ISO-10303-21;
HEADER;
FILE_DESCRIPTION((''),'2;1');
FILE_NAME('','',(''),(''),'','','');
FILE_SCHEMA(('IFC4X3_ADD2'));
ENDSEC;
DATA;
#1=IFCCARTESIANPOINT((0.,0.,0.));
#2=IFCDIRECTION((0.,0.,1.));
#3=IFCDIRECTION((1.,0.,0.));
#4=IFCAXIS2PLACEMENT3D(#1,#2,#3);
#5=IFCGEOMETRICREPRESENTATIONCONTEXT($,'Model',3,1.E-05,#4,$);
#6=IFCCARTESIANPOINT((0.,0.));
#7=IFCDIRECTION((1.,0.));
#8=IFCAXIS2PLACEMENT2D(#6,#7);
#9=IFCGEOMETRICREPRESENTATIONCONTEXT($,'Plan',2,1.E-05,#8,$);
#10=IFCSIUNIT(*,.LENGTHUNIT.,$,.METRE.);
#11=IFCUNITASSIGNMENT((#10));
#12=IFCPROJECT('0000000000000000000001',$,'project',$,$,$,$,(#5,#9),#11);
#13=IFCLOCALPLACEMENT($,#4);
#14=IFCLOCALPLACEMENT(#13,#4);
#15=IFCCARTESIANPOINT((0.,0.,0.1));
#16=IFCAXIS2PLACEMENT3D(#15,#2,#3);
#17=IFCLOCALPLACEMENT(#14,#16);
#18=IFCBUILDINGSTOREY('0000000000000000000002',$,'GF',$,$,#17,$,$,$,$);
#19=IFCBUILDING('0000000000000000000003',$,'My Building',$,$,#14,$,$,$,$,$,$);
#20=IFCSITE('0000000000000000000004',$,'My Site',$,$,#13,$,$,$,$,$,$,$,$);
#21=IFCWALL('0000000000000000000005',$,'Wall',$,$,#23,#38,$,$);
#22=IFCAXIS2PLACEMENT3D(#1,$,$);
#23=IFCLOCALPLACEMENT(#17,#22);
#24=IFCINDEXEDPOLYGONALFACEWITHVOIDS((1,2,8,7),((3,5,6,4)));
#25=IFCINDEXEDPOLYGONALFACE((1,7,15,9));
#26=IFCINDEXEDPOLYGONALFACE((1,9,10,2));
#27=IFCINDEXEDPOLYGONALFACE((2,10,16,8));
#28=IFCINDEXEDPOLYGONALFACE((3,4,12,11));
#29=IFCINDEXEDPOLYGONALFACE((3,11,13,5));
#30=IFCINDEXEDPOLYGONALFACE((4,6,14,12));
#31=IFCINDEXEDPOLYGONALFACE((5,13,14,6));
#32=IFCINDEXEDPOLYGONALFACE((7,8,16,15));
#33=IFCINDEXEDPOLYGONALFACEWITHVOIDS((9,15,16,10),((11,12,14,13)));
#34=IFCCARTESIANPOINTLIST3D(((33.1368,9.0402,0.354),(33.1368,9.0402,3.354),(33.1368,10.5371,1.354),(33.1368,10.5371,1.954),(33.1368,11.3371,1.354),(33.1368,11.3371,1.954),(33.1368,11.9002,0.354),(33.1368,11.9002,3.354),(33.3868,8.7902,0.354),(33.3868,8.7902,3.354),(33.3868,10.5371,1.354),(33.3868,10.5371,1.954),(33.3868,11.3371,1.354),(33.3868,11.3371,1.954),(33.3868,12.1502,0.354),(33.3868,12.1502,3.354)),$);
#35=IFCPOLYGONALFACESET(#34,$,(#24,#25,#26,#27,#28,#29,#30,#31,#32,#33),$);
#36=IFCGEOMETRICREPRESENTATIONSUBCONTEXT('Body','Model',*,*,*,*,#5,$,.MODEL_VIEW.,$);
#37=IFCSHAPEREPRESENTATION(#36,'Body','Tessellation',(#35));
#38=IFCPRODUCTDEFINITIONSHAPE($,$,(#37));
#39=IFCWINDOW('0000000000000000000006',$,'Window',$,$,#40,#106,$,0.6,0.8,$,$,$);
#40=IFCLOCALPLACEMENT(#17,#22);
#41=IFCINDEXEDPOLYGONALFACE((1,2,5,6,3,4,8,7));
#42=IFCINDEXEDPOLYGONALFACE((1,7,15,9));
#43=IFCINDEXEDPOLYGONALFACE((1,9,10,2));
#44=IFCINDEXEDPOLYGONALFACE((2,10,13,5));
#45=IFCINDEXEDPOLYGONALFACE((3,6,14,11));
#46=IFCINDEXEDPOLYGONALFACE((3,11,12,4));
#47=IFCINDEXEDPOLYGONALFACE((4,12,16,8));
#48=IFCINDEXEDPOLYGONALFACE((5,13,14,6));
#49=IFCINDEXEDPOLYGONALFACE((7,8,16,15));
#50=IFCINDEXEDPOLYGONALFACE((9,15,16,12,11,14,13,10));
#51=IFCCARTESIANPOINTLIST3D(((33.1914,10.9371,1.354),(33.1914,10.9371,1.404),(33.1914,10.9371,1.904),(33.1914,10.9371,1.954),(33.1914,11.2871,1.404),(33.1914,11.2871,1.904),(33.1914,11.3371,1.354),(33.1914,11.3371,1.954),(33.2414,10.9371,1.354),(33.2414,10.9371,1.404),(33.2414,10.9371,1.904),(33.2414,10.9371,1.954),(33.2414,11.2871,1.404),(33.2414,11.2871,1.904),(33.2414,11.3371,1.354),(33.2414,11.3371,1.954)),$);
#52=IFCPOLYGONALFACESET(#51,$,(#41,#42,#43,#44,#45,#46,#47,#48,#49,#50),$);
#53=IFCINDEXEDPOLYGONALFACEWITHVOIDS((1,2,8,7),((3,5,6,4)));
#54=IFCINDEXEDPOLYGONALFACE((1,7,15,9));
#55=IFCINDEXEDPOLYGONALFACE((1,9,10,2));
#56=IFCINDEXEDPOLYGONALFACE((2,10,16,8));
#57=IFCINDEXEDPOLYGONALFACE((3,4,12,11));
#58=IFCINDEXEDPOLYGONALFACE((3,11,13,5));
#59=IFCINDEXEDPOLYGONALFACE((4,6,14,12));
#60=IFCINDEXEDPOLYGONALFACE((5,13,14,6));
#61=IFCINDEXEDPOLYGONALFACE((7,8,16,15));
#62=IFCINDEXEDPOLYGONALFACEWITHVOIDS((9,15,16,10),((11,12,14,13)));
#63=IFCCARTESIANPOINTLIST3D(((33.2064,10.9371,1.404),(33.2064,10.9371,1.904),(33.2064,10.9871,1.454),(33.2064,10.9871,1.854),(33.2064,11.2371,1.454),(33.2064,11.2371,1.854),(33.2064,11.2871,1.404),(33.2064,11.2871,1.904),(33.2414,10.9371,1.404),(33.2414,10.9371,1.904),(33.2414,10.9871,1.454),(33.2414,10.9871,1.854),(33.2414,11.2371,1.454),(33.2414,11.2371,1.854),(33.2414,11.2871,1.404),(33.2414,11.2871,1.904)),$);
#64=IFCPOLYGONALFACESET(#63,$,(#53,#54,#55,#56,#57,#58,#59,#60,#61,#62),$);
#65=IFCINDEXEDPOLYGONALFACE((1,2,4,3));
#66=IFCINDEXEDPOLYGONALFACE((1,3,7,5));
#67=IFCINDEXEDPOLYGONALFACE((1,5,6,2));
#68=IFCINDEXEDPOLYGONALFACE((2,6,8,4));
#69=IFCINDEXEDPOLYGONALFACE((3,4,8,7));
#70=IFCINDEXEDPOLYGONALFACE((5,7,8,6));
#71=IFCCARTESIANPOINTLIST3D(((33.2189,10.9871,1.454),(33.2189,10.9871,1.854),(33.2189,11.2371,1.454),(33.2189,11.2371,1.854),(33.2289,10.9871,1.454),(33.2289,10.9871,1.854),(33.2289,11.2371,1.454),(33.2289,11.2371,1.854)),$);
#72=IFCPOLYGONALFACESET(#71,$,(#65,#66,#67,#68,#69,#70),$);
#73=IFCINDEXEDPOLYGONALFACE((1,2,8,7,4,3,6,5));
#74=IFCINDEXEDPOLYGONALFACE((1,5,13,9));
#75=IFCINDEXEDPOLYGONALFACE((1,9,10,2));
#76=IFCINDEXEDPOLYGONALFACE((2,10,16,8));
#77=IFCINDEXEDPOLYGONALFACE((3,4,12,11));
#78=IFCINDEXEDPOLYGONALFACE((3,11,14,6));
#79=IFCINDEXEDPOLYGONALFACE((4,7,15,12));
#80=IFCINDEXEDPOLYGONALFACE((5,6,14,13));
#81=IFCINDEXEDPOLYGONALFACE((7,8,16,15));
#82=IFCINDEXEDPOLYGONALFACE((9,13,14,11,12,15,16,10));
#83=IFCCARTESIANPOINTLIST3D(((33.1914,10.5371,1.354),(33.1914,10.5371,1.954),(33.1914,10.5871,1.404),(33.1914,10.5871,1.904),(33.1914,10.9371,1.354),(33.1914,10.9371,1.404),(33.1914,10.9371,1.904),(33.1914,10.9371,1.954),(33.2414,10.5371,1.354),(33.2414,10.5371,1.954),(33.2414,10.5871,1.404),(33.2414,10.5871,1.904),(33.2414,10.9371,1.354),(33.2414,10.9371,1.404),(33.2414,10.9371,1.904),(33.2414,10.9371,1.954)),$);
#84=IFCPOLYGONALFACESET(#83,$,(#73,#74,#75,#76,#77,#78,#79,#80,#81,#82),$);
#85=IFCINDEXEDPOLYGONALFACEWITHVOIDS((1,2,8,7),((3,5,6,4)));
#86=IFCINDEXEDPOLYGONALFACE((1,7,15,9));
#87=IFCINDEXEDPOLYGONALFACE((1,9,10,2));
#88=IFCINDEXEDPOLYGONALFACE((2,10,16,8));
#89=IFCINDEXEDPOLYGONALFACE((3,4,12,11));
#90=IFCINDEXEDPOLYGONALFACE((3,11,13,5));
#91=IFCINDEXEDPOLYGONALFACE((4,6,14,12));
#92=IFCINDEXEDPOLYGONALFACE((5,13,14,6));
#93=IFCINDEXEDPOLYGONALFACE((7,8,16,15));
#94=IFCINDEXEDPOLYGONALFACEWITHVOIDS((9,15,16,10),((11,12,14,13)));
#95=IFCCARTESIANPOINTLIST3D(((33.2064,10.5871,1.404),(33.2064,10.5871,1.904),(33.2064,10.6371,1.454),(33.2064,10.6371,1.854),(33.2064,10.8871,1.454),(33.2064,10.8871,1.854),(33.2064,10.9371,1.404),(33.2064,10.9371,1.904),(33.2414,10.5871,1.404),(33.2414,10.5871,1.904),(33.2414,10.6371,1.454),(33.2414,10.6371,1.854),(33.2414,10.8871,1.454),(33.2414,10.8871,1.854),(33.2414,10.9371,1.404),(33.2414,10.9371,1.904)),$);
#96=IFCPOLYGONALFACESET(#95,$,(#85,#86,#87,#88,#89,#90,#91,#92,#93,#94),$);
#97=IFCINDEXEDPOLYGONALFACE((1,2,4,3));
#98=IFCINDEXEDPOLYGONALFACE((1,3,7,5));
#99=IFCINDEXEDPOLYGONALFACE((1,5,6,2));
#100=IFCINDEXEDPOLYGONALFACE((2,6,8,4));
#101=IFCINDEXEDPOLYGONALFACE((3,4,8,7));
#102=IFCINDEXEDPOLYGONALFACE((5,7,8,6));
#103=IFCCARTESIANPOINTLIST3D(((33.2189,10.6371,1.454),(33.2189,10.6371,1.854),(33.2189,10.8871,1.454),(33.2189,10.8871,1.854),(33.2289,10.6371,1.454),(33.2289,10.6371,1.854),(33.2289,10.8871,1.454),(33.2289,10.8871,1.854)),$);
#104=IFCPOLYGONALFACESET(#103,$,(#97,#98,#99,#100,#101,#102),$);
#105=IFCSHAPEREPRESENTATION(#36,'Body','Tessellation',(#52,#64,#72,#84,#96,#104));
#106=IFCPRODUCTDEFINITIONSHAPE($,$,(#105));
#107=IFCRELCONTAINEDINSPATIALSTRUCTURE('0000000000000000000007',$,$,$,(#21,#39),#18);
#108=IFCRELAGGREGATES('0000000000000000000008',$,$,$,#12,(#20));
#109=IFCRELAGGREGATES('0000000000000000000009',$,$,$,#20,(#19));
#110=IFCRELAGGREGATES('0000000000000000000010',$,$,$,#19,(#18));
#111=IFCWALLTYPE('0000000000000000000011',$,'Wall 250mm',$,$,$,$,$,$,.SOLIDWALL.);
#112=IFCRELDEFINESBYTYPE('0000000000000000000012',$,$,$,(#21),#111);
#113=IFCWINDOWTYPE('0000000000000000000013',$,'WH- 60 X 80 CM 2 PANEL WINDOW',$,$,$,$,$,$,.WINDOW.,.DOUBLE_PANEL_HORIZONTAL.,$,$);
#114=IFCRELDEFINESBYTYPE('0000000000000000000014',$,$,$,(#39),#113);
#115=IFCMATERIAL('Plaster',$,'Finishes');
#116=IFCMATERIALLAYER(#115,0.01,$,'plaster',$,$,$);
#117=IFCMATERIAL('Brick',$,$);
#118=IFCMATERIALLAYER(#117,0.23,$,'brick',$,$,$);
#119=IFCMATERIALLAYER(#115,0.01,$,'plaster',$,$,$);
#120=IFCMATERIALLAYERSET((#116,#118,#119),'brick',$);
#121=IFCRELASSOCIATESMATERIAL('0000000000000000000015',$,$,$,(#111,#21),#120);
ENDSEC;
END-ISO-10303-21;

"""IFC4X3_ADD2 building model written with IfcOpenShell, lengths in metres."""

from ifc_helpers import new_model, entity, si_unit, frame, origin_with_axes, origin_2d_with_axis, place, context, subcontext, project, spatial, line, indexed_curve, outline, extrude, shape, source, transform, mapped, material, layer, layer_set, layer_usage, type_object, type_shapes, element, fill, save


model = new_model("IFC4X3_ADD2")

# Units and contexts
model_context = context("Model", 3, precision=1e-05, world=origin_with_axes())
plan_context = context("Plan", 2, precision=1e-05, world=origin_2d_with_axis())
body_context_1 = subcontext(model_context, "Body", "Model", "MODEL_VIEW")
body_context_2 = subcontext(plan_context, "Body", "Plan", "PLAN_VIEW")
ifc_project = project(units=[si_unit("LENGTHUNIT", "METRE")], contexts=[model_context, plan_context])

# Site, building, storey
site_placement = place(None, origin_with_axes())
site = spatial("IfcSite", under=ifc_project, at=site_placement, Name="My Site")
building_placement = place(site_placement, origin_with_axes())
building = spatial("IfcBuilding", under=site, at=building_placement, Name="My Building")
storey_placement = place(building_placement, frame((0.0, 0.0, 0.1), z_axis=(0.0, 0.0, 1.0), x_axis=(1.0, 0.0, 0.0)))
storey = spatial("IfcBuildingStorey", under=building, at=storey_placement, Name="GF")

# Shared definitions
ifc_material_1 = material(Name="Plaster", Category="Finishes")
ifc_layer_1 = layer(ifc_material_1, 0.01, Name="plaster")
ifc_material_2 = material(Name="Brick")
ifc_layer_2 = layer(ifc_material_2, 0.23, Name="brick")
ifc_layer_3 = layer(ifc_material_1, 0.01, Name="plaster")
ifc_layer_set_1 = layer_set([ifc_layer_1, ifc_layer_2, ifc_layer_3], Name="brick")
wall_type_1 = type_object("IfcWallType", Name="Wall 250mm", PredefinedType="SOLIDWALL", material=ifc_layer_set_1)

# Wall, opening, window
ifc_layer_usage_1 = layer_usage(ifc_layer_set_1, "AXIS2", "POSITIVE", 0.0)
wall_1_placement = place(storey_placement, frame((33.3868, 8.7902, 0.354), z_axis=(0.0, 0.0, 1.0), x_axis=(0.000001, 1.0, 0.0)))
wall_1 = element("IfcWall", 1, at=wall_1_placement, inside=storey, type_object=wall_type_1, material=ifc_layer_usage_1, Name="Wall", context=body_context_1, shape_type="SweptSolid", body=[
    extrude(outline(indexed_curve([(0.0, 0.0), (0.25, 0.25), (3.11, 0.25), (3.36, 0.0)], segments=[line(1, 2, 3, 4, 1)])), origin_with_axes(), (0.0, 0.0, 1.0), 3.0),
])
shared_shape_1 = source(origin_with_axes(), body_context_1, "Body", "SweptSolid", [
    extrude(outline(indexed_curve([(0.0, 0.0), (0.8, 0.0), (0.8, 0.6), (0.0, 0.6)], segments=[line(1, 2, 3, 4, 1)])), frame((0.0, -0.6, 0.0), z_axis=(0.0, -1.0, 0.0), x_axis=(1.0, 0.0, 0.0)), (0.0, 0.0, -1.0), 1.2),
])
opening_1_placement = place(wall_1_placement, frame((2.5469, 0.1953, 1.0), z_axis=(0.0, 0.0, 1.0), x_axis=(-1.0, 0.0, 0.0)))
opening_1 = element("IfcOpeningElement", 2, at=opening_1_placement, cuts=wall_1, PredefinedType="OPENING", context=body_context_1, shape_type="MappedRepresentation", body=[
    mapped(shared_shape_1, transform((0.0, 0.0, 0.0), x_axis=(1.0, 0.0, 0.0), y_axis=(0.0, 1.0, 0.0), z_axis=(0.0, 0.0, 1.0), scale=1.0)),
])
window_type_1 = type_object("IfcWindowType", Name="WH- 60 X 80 CM 2 PANEL WINDOW", PartitioningType="DOUBLE_PANEL_HORIZONTAL", PredefinedType="WINDOW")
shared_shape_2 = source(origin_with_axes(), body_context_1, "Body", "SweptSolid", [
    extrude(outline(indexed_curve([(0.4, 0.0), (0.0, 0.0), (0.0, 0.6), (0.4, 0.6), (0.4, 0.55), (0.05, 0.55), (0.05, 0.05), (0.4, 0.05)], segments=[line(1, 2, 3, 4, 5, 6, 7, 8, 1)])), frame((0.0, 0.0, 0.0), z_axis=(0.0, -1.0, 0.0), x_axis=(1.0, 0.0, 0.0)), (0.0, 0.0, -1.0), 0.05),
    extrude(outline(indexed_curve([(0.0, 0.0), (0.35, 0.0), (0.35, 0.5), (0.0, 0.5)], segments=[line(1, 2, 3, 4, 1)]), holes=[indexed_curve([(0.05, 0.05), (0.3, 0.05), (0.3, 0.45), (0.05, 0.45)], segments=[line(1, 2, 3, 4, 1)])]), frame((0.05, 0.015, 0.05), z_axis=(0.0, -1.0, 0.0), x_axis=(1.0, 0.0, 0.0)), (0.0, 0.0, -1.0), 0.035),
    extrude(outline(indexed_curve([(0.05, 0.05), (0.3, 0.05), (0.3, 0.45), (0.05, 0.45)], segments=[line(1, 2, 3, 4, 1)])), frame((0.05, 0.0275, 0.05), z_axis=(0.0, -1.0, 0.0), x_axis=(1.0, 0.0, 0.0)), (0.0, 0.0, -1.0), 0.01),
    extrude(outline(indexed_curve([(0.0, 0.6), (0.4, 0.6), (0.4, 0.0), (0.0, 0.0), (0.0, 0.05), (0.35, 0.05), (0.35, 0.55), (0.0, 0.55)], segments=[line(1, 2, 3, 4, 5, 6, 7, 8, 1)])), frame((0.4, 0.0, 0.0), z_axis=(0.0, -1.0, 0.0), x_axis=(1.0, 0.0, 0.0)), (0.0, 0.0, -1.0), 0.05),
    extrude(outline(indexed_curve([(0.0, 0.0), (0.35, 0.0), (0.35, 0.5), (0.0, 0.5)], segments=[line(1, 2, 3, 4, 1)]), holes=[indexed_curve([(0.05, 0.05), (0.3, 0.05), (0.3, 0.45), (0.05, 0.45)], segments=[line(1, 2, 3, 4, 1)])]), frame((0.4, 0.015, 0.05), z_axis=(0.0, -1.0, 0.0), x_axis=(1.0, 0.0, 0.0)), (0.0, 0.0, -1.0), 0.035),
    extrude(outline(indexed_curve([(0.05, 0.05), (0.3, 0.05), (0.3, 0.45), (0.05, 0.45)], segments=[line(1, 2, 3, 4, 1)])), frame((0.4, 0.0275, 0.05), z_axis=(0.0, -1.0, 0.0), x_axis=(1.0, 0.0, 0.0)), (0.0, 0.0, -1.0), 0.01),
])
shared_shape_3 = source(origin_with_axes(), body_context_2, "Body", "Curve2D", [
    entity("IfcIndexedPolyCurve", entity("IfcCartesianPointList2D", [[0.05, 0.0], [0.4, 0.0]])),
    entity("IfcIndexedPolyCurve", entity("IfcCartesianPointList2D", [[0.0, 0.05], [0.05, 0.05], [0.05, 0.0], [0.0, 0.0]]), [entity("IfcLineIndex", [1, 2, 3, 4, 1])]),
    entity("IfcIndexedPolyCurve", entity("IfcCartesianPointList2D", [[0.4, 0.05], [0.4, 0.05], [0.4, 0.0], [0.4, 0.0]])),
    entity("IfcIndexedPolyCurve", entity("IfcCartesianPointList2D", [[0.05, 0.015], [0.1, 0.015], [0.1, 0.05], [0.05, 0.05]]), [entity("IfcLineIndex", [1, 2, 3, 4, 1])]),
    entity("IfcIndexedPolyCurve", entity("IfcCartesianPointList2D", [[0.4, 0.015], [0.35, 0.015], [0.35, 0.05], [0.4, 0.05]]), [entity("IfcLineIndex", [1, 2, 3, 4, 1])]),
    entity("IfcIndexedPolyCurve", entity("IfcCartesianPointList2D", [[0.1, 0.015], [0.35, 0.015]])),
    entity("IfcIndexedPolyCurve", entity("IfcCartesianPointList2D", [[0.1, 0.05], [0.35, 0.05]])),
    entity("IfcIndexedPolyCurve", entity("IfcCartesianPointList2D", [[0.1, 0.0325], [0.35, 0.0325]])),
    entity("IfcIndexedPolyCurve", entity("IfcCartesianPointList2D", [[0.4, 0.0], [0.75, 0.0]])),
    entity("IfcIndexedPolyCurve", entity("IfcCartesianPointList2D", [[0.4, 0.05], [0.4, 0.05], [0.4, 0.0], [0.4, 0.0]])),
    entity("IfcIndexedPolyCurve", entity("IfcCartesianPointList2D", [[0.8, 0.05], [0.75, 0.05], [0.75, 0.0], [0.8, 0.0]]), [entity("IfcLineIndex", [1, 2, 3, 4, 1])]),
    entity("IfcIndexedPolyCurve", entity("IfcCartesianPointList2D", [[0.4, 0.015], [0.45, 0.015], [0.45, 0.05], [0.4, 0.05]]), [entity("IfcLineIndex", [1, 2, 3, 4, 1])]),
    entity("IfcIndexedPolyCurve", entity("IfcCartesianPointList2D", [[0.75, 0.015], [0.7, 0.015], [0.7, 0.05], [0.75, 0.05]]), [entity("IfcLineIndex", [1, 2, 3, 4, 1])]),
    entity("IfcIndexedPolyCurve", entity("IfcCartesianPointList2D", [[0.45, 0.015], [0.7, 0.015]])),
    entity("IfcIndexedPolyCurve", entity("IfcCartesianPointList2D", [[0.45, 0.05], [0.7, 0.05]])),
    entity("IfcIndexedPolyCurve", entity("IfcCartesianPointList2D", [[0.45, 0.0325], [0.7, 0.0325]])),
])
type_shapes(window_type_1, [shared_shape_2, shared_shape_3])
window_1_placement = place(opening_1_placement, frame((0.0, 0.0, 0.0), z_axis=(0.0, 0.0, 1.0), x_axis=(1.0, 0.0, 0.0)))
window_1 = element("IfcWindow", 3, at=window_1_placement, inside=storey, type_object=window_type_1, Name="Window", OverallHeight=0.6, OverallWidth=0.8, shapes=[
    shape(body_context_1, "Body", "MappedRepresentation", [mapped(shared_shape_2, transform((0.0, 0.0, 0.0), x_axis=(1.0, 0.0, 0.0), y_axis=(0.0, 1.0, 0.0), z_axis=(0.0, 0.0, 1.0), scale=1.0))]),
    shape(body_context_2, "Body", "MappedRepresentation", [mapped(shared_shape_3, transform((0.0, 0.0, 0.0), x_axis=(1.0, 0.0, 0.0), y_axis=(0.0, 1.0, 0.0), z_axis=(0.0, 0.0, 1.0), scale=1.0))]),
])
fill(opening_1, window_1)

save(model, "model.ifc")
